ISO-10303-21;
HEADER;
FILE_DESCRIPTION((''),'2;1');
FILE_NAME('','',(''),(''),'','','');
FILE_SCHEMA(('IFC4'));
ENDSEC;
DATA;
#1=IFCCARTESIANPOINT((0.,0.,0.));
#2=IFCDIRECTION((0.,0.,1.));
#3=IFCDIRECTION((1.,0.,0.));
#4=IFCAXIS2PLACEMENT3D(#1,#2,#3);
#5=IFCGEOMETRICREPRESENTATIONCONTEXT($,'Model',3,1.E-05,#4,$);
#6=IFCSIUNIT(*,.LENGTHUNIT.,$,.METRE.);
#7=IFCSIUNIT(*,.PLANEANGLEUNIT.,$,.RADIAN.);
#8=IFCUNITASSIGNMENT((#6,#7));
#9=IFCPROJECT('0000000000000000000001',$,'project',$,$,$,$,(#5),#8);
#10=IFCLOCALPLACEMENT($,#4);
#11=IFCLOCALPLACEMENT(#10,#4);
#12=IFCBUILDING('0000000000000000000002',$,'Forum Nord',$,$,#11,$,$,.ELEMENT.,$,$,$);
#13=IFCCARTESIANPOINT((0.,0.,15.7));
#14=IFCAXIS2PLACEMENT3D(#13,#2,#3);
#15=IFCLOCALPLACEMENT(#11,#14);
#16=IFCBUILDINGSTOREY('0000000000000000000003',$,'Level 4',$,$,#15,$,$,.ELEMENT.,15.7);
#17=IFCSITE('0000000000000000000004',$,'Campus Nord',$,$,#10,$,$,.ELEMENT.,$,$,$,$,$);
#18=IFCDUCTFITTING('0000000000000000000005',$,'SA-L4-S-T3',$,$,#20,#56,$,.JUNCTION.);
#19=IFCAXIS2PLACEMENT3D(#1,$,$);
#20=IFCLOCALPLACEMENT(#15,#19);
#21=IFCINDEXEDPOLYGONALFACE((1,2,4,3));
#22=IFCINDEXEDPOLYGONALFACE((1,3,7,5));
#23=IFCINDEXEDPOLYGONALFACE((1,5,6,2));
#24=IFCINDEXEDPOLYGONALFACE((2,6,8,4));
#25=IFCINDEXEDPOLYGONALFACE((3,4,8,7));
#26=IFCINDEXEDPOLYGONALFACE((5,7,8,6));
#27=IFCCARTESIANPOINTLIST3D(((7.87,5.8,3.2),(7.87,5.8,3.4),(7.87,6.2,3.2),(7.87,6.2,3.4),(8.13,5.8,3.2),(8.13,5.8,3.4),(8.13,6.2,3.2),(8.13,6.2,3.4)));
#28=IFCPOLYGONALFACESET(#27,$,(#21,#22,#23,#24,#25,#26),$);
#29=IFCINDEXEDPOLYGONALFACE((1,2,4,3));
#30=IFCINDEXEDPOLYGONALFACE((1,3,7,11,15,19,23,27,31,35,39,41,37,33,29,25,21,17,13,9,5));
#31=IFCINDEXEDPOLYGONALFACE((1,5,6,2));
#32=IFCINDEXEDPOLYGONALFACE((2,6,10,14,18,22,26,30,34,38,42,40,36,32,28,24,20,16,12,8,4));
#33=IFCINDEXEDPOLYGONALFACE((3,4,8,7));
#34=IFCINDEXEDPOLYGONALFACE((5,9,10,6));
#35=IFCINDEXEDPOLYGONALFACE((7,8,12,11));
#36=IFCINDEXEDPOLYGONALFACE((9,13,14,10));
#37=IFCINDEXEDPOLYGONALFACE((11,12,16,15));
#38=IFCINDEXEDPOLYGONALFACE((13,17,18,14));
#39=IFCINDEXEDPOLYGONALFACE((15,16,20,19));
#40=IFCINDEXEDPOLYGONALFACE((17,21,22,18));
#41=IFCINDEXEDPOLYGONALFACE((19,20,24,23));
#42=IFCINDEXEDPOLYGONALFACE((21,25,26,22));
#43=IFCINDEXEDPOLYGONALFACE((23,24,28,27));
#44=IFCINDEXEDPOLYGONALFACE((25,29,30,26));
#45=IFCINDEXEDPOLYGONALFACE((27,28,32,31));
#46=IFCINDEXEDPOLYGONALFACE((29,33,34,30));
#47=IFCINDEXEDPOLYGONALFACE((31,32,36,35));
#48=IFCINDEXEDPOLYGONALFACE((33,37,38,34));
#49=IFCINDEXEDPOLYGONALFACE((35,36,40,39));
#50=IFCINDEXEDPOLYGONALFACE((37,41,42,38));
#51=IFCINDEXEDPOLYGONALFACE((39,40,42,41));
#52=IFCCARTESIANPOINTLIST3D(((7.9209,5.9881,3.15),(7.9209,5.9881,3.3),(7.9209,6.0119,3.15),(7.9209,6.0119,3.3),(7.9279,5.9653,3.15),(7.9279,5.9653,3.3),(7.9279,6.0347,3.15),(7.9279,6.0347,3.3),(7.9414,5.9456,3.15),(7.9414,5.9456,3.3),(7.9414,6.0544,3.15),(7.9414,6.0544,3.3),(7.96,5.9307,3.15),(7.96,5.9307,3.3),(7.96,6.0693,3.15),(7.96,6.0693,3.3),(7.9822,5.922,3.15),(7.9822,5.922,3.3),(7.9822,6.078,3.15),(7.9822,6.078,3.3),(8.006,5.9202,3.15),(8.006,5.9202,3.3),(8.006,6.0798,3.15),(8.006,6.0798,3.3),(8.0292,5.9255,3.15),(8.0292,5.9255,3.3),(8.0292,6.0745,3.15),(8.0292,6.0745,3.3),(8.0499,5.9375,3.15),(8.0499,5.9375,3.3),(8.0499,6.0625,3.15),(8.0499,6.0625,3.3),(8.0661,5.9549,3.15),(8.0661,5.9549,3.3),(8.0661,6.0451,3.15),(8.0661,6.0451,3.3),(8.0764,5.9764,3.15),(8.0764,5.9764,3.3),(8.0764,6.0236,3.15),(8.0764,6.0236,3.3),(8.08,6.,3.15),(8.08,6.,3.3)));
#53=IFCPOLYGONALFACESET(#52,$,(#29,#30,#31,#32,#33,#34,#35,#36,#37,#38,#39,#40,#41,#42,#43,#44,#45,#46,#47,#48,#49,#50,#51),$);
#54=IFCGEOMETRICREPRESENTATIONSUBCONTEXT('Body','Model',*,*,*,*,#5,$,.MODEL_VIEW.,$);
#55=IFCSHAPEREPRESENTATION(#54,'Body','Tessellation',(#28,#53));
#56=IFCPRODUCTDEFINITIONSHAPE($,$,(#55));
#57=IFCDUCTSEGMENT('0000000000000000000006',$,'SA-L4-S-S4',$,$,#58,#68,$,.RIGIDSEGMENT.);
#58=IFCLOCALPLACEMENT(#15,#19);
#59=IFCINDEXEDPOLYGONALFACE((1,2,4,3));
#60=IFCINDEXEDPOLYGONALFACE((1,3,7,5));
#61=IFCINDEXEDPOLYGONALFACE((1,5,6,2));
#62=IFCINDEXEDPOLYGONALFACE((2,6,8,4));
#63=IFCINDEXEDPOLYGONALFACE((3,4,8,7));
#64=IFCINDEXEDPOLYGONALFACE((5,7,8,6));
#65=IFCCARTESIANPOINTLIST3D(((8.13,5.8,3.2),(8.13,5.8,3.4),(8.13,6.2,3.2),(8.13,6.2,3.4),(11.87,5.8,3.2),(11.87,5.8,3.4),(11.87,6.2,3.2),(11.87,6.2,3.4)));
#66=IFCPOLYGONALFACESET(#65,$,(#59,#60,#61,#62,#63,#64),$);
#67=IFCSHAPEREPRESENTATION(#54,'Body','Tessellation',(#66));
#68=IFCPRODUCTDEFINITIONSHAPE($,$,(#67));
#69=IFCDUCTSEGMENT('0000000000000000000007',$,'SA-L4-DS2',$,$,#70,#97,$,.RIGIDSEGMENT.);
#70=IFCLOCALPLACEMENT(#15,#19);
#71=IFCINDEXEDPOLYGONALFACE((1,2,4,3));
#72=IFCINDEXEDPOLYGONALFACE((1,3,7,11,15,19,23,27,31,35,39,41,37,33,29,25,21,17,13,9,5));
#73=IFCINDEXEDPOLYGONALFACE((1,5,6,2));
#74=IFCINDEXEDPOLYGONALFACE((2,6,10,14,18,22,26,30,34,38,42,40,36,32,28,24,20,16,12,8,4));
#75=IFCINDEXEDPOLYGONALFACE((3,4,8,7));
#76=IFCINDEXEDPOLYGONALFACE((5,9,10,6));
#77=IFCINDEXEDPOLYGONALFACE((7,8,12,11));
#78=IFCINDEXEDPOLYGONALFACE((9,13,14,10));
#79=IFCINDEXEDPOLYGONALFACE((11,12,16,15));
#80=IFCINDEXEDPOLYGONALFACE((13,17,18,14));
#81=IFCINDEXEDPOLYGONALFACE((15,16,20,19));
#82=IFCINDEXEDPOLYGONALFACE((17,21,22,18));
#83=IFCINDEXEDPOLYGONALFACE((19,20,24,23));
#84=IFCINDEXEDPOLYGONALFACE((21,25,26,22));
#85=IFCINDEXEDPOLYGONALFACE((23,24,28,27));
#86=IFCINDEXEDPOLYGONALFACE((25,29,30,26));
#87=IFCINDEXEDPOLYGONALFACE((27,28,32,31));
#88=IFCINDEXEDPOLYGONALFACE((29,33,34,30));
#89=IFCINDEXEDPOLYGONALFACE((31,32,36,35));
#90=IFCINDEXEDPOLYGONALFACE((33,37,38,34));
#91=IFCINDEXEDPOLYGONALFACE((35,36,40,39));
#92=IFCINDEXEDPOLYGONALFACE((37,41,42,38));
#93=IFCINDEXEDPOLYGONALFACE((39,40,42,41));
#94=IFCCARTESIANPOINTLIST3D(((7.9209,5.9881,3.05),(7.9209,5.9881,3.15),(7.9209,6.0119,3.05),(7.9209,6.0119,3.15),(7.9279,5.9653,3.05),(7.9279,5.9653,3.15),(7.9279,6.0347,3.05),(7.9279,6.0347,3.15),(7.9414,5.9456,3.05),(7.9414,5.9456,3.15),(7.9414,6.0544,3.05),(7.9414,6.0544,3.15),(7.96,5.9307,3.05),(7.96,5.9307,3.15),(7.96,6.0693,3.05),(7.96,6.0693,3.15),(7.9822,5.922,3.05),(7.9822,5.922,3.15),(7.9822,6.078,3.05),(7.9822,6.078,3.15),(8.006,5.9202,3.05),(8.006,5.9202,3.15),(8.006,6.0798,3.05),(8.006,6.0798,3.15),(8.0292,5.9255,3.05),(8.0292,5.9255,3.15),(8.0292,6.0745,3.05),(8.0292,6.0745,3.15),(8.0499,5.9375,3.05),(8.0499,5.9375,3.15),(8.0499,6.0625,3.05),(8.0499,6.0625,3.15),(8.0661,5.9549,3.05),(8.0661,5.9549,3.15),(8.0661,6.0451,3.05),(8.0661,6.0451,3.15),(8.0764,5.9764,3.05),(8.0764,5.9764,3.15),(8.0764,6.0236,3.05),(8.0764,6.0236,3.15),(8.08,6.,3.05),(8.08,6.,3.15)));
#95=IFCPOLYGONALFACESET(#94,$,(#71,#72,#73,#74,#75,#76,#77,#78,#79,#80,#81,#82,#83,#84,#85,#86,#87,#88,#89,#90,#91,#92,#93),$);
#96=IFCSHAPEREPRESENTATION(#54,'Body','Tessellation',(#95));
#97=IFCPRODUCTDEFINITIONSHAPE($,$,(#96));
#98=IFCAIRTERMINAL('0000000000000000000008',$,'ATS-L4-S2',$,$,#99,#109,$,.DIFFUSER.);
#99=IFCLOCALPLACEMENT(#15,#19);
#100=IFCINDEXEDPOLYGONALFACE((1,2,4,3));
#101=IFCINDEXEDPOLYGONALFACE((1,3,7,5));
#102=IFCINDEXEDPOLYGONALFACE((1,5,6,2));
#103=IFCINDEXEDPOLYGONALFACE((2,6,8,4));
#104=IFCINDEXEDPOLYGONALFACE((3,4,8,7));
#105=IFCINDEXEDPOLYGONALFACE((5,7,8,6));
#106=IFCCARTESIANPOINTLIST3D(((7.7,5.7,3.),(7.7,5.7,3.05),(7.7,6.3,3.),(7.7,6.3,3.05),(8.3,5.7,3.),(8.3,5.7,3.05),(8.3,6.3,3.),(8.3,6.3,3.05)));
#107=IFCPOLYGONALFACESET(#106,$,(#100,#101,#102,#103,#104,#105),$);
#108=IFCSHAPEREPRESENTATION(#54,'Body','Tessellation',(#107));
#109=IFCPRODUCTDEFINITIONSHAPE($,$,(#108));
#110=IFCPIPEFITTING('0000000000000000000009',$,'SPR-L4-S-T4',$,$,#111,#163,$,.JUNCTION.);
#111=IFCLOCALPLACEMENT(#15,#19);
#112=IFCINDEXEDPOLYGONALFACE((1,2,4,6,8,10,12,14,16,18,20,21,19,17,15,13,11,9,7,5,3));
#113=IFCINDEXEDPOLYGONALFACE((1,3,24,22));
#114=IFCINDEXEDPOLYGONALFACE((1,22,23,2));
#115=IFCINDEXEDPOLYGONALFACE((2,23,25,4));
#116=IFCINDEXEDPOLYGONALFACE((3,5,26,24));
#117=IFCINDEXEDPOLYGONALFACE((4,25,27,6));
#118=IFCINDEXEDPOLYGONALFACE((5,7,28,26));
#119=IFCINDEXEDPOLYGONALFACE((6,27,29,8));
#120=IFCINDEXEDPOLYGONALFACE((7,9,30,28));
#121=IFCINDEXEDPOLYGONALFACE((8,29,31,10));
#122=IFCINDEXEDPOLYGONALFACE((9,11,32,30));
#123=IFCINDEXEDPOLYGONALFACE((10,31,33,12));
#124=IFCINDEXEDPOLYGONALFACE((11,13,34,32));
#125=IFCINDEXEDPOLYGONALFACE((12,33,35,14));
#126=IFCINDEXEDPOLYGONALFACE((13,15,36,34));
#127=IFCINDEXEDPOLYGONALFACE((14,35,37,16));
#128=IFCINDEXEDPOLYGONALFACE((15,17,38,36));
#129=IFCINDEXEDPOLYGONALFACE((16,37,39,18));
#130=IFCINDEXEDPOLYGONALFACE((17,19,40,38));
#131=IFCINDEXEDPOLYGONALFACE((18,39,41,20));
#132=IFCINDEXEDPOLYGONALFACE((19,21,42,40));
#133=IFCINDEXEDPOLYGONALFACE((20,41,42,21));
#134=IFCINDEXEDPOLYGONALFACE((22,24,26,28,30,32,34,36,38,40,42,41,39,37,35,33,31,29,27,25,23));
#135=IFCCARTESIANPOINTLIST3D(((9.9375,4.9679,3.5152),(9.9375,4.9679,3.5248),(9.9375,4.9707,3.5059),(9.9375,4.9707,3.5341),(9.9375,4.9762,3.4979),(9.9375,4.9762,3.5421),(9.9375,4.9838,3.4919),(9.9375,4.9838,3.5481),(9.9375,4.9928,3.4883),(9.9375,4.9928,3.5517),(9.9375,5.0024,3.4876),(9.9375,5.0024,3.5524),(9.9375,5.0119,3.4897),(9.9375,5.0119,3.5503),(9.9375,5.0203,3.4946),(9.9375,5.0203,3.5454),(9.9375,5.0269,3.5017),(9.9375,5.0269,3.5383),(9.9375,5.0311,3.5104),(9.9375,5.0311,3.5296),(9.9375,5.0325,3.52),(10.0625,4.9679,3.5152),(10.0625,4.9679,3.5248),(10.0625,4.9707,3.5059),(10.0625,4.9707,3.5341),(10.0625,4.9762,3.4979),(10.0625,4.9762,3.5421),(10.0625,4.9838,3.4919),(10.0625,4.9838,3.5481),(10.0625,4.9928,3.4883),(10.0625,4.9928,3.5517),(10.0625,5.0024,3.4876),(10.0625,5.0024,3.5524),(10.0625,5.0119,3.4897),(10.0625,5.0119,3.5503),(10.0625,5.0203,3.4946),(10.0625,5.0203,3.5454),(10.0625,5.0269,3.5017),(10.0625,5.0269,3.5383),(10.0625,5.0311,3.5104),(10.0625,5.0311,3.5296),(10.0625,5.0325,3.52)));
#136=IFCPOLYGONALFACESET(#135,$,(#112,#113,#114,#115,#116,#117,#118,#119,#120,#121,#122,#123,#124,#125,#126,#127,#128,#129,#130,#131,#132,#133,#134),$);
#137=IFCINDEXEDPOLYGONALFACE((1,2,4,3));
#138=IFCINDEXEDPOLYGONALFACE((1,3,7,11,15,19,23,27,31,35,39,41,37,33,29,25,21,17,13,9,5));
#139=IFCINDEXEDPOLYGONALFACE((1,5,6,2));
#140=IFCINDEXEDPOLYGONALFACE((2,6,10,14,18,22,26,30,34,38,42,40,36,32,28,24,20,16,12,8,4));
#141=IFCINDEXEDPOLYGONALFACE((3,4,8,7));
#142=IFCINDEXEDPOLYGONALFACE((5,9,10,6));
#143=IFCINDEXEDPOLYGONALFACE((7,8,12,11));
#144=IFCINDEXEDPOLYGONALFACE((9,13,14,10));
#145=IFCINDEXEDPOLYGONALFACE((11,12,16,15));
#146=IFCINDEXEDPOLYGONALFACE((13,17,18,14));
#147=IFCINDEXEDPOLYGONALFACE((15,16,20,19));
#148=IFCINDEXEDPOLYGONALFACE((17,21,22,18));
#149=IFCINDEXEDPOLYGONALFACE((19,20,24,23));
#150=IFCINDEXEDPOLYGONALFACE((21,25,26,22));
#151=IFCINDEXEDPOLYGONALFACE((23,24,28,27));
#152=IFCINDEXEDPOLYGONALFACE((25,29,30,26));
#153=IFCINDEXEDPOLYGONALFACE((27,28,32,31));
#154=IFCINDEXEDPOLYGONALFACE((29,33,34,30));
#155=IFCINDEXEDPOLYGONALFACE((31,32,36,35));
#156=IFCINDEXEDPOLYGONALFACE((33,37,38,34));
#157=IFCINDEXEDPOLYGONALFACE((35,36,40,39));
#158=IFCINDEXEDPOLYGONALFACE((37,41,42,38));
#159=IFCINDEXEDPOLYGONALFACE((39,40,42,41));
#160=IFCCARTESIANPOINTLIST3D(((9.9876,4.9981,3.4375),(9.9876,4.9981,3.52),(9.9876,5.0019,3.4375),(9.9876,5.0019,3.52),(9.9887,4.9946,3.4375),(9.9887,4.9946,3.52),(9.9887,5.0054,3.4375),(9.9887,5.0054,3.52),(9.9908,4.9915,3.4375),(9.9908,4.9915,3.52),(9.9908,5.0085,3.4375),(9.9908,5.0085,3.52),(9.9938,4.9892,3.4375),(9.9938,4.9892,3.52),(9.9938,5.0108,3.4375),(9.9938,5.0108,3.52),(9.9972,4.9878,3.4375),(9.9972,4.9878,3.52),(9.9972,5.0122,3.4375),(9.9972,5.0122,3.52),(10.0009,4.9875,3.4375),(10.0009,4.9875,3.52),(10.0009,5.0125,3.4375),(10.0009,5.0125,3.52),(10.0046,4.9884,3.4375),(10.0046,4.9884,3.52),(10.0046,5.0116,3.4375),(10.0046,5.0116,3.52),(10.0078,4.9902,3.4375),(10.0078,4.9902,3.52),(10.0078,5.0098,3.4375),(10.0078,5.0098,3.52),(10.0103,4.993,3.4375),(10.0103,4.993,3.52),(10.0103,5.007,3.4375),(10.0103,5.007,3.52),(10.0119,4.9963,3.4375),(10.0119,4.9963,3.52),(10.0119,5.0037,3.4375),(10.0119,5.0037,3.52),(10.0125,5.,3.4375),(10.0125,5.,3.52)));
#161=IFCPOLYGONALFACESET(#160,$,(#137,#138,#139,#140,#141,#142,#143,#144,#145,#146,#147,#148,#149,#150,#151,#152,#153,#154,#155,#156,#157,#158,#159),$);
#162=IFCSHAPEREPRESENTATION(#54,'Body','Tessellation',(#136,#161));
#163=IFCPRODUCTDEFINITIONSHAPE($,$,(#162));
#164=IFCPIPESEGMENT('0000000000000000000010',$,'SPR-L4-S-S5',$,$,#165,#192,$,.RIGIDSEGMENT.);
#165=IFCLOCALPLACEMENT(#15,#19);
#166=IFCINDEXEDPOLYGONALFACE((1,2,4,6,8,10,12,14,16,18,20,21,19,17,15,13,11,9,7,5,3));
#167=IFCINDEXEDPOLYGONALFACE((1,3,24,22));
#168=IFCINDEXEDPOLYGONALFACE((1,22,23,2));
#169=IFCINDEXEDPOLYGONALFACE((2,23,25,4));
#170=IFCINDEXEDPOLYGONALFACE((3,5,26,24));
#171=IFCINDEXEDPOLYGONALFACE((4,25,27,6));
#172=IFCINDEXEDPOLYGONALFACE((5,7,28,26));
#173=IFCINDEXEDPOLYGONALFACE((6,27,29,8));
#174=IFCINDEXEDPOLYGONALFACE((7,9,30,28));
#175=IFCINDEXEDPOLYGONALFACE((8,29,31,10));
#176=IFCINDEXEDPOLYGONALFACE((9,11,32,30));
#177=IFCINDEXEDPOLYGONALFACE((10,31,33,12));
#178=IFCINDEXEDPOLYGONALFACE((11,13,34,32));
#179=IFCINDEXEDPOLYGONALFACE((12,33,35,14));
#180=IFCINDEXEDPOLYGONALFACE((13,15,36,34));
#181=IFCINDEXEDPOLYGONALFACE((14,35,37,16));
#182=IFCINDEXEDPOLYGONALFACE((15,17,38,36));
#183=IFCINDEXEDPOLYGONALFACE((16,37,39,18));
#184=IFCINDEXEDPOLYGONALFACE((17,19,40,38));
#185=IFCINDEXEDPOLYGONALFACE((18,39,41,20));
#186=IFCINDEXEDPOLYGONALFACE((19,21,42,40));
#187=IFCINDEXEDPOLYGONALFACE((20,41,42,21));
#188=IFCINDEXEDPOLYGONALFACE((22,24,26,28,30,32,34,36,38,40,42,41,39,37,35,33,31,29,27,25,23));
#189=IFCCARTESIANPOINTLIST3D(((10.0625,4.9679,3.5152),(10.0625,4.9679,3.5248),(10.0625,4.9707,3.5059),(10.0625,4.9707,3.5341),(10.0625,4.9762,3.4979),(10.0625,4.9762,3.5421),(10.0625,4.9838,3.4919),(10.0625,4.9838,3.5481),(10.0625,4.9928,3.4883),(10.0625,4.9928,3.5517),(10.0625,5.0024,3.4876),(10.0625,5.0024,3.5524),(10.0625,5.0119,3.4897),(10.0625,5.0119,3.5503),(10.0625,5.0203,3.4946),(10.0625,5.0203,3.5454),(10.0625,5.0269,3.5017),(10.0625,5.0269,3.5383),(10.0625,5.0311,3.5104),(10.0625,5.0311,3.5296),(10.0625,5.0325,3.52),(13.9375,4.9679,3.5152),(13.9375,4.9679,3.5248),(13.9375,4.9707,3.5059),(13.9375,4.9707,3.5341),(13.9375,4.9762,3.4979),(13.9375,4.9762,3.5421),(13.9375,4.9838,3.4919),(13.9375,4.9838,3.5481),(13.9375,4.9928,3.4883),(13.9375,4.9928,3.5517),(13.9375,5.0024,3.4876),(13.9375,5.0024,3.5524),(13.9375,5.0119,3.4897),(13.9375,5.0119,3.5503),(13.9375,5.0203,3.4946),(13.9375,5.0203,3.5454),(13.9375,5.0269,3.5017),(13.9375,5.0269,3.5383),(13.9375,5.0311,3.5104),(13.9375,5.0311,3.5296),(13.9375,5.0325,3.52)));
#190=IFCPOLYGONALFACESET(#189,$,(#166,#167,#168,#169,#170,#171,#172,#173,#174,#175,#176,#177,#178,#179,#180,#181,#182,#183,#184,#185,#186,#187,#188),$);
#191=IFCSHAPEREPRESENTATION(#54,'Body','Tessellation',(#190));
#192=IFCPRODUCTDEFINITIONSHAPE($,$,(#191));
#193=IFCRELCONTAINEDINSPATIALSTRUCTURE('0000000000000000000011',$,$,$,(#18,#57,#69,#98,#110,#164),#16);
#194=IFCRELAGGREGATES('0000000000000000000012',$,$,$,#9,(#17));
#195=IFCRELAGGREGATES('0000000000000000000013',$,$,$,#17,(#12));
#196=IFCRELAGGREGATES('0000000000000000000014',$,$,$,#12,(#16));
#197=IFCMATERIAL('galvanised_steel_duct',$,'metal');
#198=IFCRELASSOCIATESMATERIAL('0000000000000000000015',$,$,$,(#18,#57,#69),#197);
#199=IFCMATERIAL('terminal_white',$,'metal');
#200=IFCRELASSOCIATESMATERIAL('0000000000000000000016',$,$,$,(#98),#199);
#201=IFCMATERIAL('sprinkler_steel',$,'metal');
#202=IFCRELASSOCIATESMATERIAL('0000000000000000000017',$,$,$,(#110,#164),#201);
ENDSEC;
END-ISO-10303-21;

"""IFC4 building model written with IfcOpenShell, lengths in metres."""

from ifc_helpers import new_model, si_unit, frame, origin_with_axes, origin_2d_with_axis, place, context, subcontext, project, spatial, rectangle, circle, extrude, material, element, save


model = new_model("IFC4")

# Units and contexts
model_context = context("Model", 3, precision=1e-05, world=origin_with_axes())
body_context = subcontext(model_context, "Body", "Model", "MODEL_VIEW")
ifc_project = project(units=[si_unit("LENGTHUNIT", "METRE"), si_unit("PLANEANGLEUNIT", "RADIAN")], contexts=[model_context])

# Site, building, storey
site_placement = place(None, origin_with_axes())
site = spatial("IfcSite", under=ifc_project, at=site_placement, Name="Campus Nord", CompositionType="ELEMENT")
building_placement = place(site_placement, origin_with_axes())
building = spatial("IfcBuilding", under=site, at=building_placement, Name="Forum Nord", CompositionType="ELEMENT")
storey_placement = place(building_placement, frame((0.0, 0.0, 15.7), z_axis=(0.0, 0.0, 1.0), x_axis=(1.0, 0.0, 0.0)))
storey = spatial("IfcBuildingStorey", under=building, at=storey_placement, Name="Level 4", CompositionType="ELEMENT", Elevation=15.7)

# Duct fitting
ifc_material_1 = material(Name="galvanised_steel_duct", Category="metal")
duct_fitting_placement = place(storey_placement, frame((7.87, 6.0, 3.3), z_axis=(1.0, 0.0, 0.0), x_axis=(0.0, 1.0, 0.0)))
element("IfcDuctFitting", 1, at=duct_fitting_placement, inside=storey, material=ifc_material_1, Name="SA-L4-S-T3", PredefinedType="JUNCTION", context=body_context, shape_type="SweptSolid", body=[
    extrude(rectangle(XDim=0.4, YDim=0.2, at=origin_2d_with_axis()), origin_with_axes(), (0.0, 0.0, 1.0), 0.26),
    extrude(circle(Radius=0.08, at=origin_2d_with_axis()), frame((0.0, 0.0, 0.13), z_axis=(0.0, -1.0, 0.0), x_axis=(0.0, 0.0, 1.0)), (0.0, 0.0, 1.0), 0.15),
])

# Duct segments
duct_segment_1_placement = place(storey_placement, frame((8.13, 6.0, 3.3), z_axis=(1.0, 0.0, 0.0), x_axis=(0.0, 1.0, 0.0)))
element("IfcDuctSegment", 2, at=duct_segment_1_placement, inside=storey, material=ifc_material_1, Name="SA-L4-S-S4", PredefinedType="RIGIDSEGMENT", context=body_context, shape_type="SweptSolid", body=[
    extrude(rectangle(XDim=0.4, YDim=0.2, at=origin_2d_with_axis()), origin_with_axes(), (0.0, 0.0, 1.0), 3.74),
])
duct_segment_2_placement = place(storey_placement, frame((8.0, 6.0, 3.15), z_axis=(0.0, 0.0, -1.0), x_axis=(1.0, 0.0, 0.0)))
element("IfcDuctSegment", 3, at=duct_segment_2_placement, inside=storey, material=ifc_material_1, Name="SA-L4-DS2", PredefinedType="RIGIDSEGMENT", context=body_context, shape_type="SweptSolid", body=[
    extrude(circle(Radius=0.08, at=origin_2d_with_axis()), origin_with_axes(), (0.0, 0.0, 1.0), 0.1),
])

# Air terminal
ifc_material_2 = material(Name="terminal_white", Category="metal")
air_terminal_placement = place(storey_placement, frame((8.0, 6.0, 3.0), z_axis=(0.0, 0.0, 1.0), x_axis=(1.0, 0.0, 0.0)))
element("IfcAirTerminal", 4, at=air_terminal_placement, inside=storey, material=ifc_material_2, Name="ATS-L4-S2", PredefinedType="DIFFUSER", context=body_context, shape_type="SweptSolid", body=[
    extrude(rectangle(XDim=0.6, YDim=0.6, at=origin_2d_with_axis()), origin_with_axes(), (0.0, 0.0, 1.0), 0.05),
])

# Pipe fitting
ifc_material_3 = material(Name="sprinkler_steel", Category="metal")
pipe_fitting_1_placement = place(storey_placement, frame((9.9375, 5.0, 3.52), z_axis=(1.0, 0.0, 0.0), x_axis=(0.0, 1.0, 0.0)))
element("IfcPipeFitting", 5, at=pipe_fitting_1_placement, inside=storey, material=ifc_material_3, Name="SPR-L4-S-T4", PredefinedType="JUNCTION", context=body_context, shape_type="SweptSolid", body=[
    extrude(circle(Radius=0.0325, at=origin_2d_with_axis()), origin_with_axes(), (0.0, 0.0, 1.0), 0.125),
    extrude(circle(Radius=0.0125, at=origin_2d_with_axis()), frame((0.0, 0.0, 0.0625), z_axis=(0.0, -1.0, 0.0), x_axis=(0.0, 0.0, 1.0)), (0.0, 0.0, 1.0), 0.0825),
])

# Pipe segment
pipe_segment_1_placement = place(storey_placement, frame((10.0625, 5.0, 3.52), z_axis=(1.0, 0.0, 0.0), x_axis=(0.0, 1.0, 0.0)))
element("IfcPipeSegment", 6, at=pipe_segment_1_placement, inside=storey, material=ifc_material_3, Name="SPR-L4-S-S5", PredefinedType="RIGIDSEGMENT", context=body_context, shape_type="SweptSolid", body=[
    extrude(circle(Radius=0.0325, at=origin_2d_with_axis()), origin_with_axes(), (0.0, 0.0, 1.0), 3.875),
])

save(model, "model.ifc")
